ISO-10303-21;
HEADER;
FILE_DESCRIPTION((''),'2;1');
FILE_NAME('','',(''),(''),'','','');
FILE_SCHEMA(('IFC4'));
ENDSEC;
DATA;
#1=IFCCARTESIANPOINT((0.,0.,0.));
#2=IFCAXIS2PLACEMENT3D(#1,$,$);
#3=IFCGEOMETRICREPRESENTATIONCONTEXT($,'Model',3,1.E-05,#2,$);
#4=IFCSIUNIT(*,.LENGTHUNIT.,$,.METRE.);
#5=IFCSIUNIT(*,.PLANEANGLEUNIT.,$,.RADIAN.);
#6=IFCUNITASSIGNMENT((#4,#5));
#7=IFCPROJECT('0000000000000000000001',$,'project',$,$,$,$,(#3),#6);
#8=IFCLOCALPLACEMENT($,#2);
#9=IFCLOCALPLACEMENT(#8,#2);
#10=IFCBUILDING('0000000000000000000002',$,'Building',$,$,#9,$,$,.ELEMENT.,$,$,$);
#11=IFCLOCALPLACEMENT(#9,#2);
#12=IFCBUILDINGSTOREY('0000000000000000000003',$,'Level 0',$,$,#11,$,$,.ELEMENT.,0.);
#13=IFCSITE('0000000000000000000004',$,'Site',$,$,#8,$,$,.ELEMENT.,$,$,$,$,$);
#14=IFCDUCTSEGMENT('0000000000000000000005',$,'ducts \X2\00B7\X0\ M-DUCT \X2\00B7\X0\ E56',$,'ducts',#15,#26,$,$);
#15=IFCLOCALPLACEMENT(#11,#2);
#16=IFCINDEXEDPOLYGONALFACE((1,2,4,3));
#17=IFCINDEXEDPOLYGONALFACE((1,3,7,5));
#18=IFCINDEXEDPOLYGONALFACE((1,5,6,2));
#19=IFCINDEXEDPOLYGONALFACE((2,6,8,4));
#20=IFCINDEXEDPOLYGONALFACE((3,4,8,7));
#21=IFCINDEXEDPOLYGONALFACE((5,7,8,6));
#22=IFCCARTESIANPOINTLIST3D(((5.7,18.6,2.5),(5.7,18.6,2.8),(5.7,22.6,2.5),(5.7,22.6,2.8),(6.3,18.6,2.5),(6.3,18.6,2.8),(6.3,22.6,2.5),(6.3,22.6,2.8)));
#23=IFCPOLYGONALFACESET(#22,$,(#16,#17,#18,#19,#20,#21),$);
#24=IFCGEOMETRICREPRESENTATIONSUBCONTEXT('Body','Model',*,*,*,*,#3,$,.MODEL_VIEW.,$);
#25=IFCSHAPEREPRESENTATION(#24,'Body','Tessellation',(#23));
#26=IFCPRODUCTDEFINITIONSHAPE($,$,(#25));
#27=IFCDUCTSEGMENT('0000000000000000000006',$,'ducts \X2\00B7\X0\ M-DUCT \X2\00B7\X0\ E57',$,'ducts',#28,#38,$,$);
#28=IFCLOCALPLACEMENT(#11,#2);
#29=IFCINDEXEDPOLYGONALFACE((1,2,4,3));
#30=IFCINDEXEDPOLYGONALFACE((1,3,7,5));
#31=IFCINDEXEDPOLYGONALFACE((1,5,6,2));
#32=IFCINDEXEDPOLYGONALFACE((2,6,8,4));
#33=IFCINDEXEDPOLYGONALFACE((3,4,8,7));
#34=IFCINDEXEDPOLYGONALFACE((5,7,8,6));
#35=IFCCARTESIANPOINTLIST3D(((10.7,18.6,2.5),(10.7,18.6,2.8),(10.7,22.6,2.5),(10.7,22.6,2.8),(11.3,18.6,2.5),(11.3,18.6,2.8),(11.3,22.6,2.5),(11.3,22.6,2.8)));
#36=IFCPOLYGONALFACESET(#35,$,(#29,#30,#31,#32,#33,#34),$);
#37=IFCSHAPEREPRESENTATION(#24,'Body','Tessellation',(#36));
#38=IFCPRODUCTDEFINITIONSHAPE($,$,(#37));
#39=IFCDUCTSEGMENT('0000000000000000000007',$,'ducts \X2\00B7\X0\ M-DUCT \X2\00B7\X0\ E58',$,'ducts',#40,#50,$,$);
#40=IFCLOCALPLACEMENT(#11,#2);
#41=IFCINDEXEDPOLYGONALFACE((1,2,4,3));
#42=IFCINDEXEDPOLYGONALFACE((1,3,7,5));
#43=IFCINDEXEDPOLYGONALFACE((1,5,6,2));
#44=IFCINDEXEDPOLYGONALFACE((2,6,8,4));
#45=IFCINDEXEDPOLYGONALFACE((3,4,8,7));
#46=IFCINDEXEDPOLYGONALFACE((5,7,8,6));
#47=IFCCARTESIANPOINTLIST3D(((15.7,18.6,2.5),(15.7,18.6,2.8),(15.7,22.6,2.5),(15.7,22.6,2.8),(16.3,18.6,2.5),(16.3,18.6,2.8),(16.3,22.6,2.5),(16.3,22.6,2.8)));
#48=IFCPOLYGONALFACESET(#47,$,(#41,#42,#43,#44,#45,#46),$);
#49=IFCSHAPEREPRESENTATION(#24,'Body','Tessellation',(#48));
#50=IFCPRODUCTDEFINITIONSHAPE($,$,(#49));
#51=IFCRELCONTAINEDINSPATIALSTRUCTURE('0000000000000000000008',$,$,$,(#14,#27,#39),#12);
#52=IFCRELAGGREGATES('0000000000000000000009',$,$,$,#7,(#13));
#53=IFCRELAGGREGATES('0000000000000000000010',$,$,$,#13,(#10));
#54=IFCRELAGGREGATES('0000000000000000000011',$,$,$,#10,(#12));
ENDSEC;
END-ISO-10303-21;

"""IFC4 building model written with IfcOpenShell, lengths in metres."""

from ifc_helpers import new_model, si_unit, frame, origin, place, context, subcontext, project, spatial, polyline, outline, extrude, element, save


model = new_model("IFC4")

# Units and contexts
model_context = context("Model", 3, precision=1e-05, world=origin())
body_context = subcontext(model_context, "Body", "Model", "MODEL_VIEW")
ifc_project = project(units=[si_unit("LENGTHUNIT", "METRE"), si_unit("PLANEANGLEUNIT", "RADIAN")], contexts=[model_context])

# Site, building, storey
site_placement = place(None, origin())
site = spatial("IfcSite", under=ifc_project, at=site_placement, Name="Site", CompositionType="ELEMENT")
building_placement = place(site_placement, origin())
building = spatial("IfcBuilding", under=site, at=building_placement, Name="Building", CompositionType="ELEMENT")
storey_placement = place(building_placement, origin())
storey = spatial("IfcBuildingStorey", under=building, at=storey_placement, Name="Level 0", CompositionType="ELEMENT", Elevation=0.0)

# Duct segments
duct_segment_1_placement = place(storey_placement, frame((0.0, 0.0, 2.5)))
element("IfcDuctSegment", 1, at=duct_segment_1_placement, inside=storey, Name="ducts · M-DUCT · E56", ObjectType="ducts", context=body_context, shape_type="SweptSolid", body=[
    extrude(outline(polyline([(5.7, 22.6), (5.7, 18.6), (6.3, 18.6), (6.3, 22.6), (5.7, 22.6)])), origin(), (0.0, 0.0, 1.0), 0.3),
])
duct_segment_2_placement = place(storey_placement, frame((0.0, 0.0, 2.5)))
element("IfcDuctSegment", 2, at=duct_segment_2_placement, inside=storey, Name="ducts · M-DUCT · E57", ObjectType="ducts", context=body_context, shape_type="SweptSolid", body=[
    extrude(outline(polyline([(10.7, 22.6), (10.7, 18.6), (11.3, 18.6), (11.3, 22.6), (10.7, 22.6)])), origin(), (0.0, 0.0, 1.0), 0.3),
])
duct_segment_3_placement = place(storey_placement, frame((0.0, 0.0, 2.5)))
element("IfcDuctSegment", 3, at=duct_segment_3_placement, inside=storey, Name="ducts · M-DUCT · E58", ObjectType="ducts", context=body_context, shape_type="SweptSolid", body=[
    extrude(outline(polyline([(15.7, 22.6), (15.7, 18.6), (16.3, 18.6), (16.3, 22.6), (15.7, 22.6)])), origin(), (0.0, 0.0, 1.0), 0.3),
])

save(model, "model.ifc")
